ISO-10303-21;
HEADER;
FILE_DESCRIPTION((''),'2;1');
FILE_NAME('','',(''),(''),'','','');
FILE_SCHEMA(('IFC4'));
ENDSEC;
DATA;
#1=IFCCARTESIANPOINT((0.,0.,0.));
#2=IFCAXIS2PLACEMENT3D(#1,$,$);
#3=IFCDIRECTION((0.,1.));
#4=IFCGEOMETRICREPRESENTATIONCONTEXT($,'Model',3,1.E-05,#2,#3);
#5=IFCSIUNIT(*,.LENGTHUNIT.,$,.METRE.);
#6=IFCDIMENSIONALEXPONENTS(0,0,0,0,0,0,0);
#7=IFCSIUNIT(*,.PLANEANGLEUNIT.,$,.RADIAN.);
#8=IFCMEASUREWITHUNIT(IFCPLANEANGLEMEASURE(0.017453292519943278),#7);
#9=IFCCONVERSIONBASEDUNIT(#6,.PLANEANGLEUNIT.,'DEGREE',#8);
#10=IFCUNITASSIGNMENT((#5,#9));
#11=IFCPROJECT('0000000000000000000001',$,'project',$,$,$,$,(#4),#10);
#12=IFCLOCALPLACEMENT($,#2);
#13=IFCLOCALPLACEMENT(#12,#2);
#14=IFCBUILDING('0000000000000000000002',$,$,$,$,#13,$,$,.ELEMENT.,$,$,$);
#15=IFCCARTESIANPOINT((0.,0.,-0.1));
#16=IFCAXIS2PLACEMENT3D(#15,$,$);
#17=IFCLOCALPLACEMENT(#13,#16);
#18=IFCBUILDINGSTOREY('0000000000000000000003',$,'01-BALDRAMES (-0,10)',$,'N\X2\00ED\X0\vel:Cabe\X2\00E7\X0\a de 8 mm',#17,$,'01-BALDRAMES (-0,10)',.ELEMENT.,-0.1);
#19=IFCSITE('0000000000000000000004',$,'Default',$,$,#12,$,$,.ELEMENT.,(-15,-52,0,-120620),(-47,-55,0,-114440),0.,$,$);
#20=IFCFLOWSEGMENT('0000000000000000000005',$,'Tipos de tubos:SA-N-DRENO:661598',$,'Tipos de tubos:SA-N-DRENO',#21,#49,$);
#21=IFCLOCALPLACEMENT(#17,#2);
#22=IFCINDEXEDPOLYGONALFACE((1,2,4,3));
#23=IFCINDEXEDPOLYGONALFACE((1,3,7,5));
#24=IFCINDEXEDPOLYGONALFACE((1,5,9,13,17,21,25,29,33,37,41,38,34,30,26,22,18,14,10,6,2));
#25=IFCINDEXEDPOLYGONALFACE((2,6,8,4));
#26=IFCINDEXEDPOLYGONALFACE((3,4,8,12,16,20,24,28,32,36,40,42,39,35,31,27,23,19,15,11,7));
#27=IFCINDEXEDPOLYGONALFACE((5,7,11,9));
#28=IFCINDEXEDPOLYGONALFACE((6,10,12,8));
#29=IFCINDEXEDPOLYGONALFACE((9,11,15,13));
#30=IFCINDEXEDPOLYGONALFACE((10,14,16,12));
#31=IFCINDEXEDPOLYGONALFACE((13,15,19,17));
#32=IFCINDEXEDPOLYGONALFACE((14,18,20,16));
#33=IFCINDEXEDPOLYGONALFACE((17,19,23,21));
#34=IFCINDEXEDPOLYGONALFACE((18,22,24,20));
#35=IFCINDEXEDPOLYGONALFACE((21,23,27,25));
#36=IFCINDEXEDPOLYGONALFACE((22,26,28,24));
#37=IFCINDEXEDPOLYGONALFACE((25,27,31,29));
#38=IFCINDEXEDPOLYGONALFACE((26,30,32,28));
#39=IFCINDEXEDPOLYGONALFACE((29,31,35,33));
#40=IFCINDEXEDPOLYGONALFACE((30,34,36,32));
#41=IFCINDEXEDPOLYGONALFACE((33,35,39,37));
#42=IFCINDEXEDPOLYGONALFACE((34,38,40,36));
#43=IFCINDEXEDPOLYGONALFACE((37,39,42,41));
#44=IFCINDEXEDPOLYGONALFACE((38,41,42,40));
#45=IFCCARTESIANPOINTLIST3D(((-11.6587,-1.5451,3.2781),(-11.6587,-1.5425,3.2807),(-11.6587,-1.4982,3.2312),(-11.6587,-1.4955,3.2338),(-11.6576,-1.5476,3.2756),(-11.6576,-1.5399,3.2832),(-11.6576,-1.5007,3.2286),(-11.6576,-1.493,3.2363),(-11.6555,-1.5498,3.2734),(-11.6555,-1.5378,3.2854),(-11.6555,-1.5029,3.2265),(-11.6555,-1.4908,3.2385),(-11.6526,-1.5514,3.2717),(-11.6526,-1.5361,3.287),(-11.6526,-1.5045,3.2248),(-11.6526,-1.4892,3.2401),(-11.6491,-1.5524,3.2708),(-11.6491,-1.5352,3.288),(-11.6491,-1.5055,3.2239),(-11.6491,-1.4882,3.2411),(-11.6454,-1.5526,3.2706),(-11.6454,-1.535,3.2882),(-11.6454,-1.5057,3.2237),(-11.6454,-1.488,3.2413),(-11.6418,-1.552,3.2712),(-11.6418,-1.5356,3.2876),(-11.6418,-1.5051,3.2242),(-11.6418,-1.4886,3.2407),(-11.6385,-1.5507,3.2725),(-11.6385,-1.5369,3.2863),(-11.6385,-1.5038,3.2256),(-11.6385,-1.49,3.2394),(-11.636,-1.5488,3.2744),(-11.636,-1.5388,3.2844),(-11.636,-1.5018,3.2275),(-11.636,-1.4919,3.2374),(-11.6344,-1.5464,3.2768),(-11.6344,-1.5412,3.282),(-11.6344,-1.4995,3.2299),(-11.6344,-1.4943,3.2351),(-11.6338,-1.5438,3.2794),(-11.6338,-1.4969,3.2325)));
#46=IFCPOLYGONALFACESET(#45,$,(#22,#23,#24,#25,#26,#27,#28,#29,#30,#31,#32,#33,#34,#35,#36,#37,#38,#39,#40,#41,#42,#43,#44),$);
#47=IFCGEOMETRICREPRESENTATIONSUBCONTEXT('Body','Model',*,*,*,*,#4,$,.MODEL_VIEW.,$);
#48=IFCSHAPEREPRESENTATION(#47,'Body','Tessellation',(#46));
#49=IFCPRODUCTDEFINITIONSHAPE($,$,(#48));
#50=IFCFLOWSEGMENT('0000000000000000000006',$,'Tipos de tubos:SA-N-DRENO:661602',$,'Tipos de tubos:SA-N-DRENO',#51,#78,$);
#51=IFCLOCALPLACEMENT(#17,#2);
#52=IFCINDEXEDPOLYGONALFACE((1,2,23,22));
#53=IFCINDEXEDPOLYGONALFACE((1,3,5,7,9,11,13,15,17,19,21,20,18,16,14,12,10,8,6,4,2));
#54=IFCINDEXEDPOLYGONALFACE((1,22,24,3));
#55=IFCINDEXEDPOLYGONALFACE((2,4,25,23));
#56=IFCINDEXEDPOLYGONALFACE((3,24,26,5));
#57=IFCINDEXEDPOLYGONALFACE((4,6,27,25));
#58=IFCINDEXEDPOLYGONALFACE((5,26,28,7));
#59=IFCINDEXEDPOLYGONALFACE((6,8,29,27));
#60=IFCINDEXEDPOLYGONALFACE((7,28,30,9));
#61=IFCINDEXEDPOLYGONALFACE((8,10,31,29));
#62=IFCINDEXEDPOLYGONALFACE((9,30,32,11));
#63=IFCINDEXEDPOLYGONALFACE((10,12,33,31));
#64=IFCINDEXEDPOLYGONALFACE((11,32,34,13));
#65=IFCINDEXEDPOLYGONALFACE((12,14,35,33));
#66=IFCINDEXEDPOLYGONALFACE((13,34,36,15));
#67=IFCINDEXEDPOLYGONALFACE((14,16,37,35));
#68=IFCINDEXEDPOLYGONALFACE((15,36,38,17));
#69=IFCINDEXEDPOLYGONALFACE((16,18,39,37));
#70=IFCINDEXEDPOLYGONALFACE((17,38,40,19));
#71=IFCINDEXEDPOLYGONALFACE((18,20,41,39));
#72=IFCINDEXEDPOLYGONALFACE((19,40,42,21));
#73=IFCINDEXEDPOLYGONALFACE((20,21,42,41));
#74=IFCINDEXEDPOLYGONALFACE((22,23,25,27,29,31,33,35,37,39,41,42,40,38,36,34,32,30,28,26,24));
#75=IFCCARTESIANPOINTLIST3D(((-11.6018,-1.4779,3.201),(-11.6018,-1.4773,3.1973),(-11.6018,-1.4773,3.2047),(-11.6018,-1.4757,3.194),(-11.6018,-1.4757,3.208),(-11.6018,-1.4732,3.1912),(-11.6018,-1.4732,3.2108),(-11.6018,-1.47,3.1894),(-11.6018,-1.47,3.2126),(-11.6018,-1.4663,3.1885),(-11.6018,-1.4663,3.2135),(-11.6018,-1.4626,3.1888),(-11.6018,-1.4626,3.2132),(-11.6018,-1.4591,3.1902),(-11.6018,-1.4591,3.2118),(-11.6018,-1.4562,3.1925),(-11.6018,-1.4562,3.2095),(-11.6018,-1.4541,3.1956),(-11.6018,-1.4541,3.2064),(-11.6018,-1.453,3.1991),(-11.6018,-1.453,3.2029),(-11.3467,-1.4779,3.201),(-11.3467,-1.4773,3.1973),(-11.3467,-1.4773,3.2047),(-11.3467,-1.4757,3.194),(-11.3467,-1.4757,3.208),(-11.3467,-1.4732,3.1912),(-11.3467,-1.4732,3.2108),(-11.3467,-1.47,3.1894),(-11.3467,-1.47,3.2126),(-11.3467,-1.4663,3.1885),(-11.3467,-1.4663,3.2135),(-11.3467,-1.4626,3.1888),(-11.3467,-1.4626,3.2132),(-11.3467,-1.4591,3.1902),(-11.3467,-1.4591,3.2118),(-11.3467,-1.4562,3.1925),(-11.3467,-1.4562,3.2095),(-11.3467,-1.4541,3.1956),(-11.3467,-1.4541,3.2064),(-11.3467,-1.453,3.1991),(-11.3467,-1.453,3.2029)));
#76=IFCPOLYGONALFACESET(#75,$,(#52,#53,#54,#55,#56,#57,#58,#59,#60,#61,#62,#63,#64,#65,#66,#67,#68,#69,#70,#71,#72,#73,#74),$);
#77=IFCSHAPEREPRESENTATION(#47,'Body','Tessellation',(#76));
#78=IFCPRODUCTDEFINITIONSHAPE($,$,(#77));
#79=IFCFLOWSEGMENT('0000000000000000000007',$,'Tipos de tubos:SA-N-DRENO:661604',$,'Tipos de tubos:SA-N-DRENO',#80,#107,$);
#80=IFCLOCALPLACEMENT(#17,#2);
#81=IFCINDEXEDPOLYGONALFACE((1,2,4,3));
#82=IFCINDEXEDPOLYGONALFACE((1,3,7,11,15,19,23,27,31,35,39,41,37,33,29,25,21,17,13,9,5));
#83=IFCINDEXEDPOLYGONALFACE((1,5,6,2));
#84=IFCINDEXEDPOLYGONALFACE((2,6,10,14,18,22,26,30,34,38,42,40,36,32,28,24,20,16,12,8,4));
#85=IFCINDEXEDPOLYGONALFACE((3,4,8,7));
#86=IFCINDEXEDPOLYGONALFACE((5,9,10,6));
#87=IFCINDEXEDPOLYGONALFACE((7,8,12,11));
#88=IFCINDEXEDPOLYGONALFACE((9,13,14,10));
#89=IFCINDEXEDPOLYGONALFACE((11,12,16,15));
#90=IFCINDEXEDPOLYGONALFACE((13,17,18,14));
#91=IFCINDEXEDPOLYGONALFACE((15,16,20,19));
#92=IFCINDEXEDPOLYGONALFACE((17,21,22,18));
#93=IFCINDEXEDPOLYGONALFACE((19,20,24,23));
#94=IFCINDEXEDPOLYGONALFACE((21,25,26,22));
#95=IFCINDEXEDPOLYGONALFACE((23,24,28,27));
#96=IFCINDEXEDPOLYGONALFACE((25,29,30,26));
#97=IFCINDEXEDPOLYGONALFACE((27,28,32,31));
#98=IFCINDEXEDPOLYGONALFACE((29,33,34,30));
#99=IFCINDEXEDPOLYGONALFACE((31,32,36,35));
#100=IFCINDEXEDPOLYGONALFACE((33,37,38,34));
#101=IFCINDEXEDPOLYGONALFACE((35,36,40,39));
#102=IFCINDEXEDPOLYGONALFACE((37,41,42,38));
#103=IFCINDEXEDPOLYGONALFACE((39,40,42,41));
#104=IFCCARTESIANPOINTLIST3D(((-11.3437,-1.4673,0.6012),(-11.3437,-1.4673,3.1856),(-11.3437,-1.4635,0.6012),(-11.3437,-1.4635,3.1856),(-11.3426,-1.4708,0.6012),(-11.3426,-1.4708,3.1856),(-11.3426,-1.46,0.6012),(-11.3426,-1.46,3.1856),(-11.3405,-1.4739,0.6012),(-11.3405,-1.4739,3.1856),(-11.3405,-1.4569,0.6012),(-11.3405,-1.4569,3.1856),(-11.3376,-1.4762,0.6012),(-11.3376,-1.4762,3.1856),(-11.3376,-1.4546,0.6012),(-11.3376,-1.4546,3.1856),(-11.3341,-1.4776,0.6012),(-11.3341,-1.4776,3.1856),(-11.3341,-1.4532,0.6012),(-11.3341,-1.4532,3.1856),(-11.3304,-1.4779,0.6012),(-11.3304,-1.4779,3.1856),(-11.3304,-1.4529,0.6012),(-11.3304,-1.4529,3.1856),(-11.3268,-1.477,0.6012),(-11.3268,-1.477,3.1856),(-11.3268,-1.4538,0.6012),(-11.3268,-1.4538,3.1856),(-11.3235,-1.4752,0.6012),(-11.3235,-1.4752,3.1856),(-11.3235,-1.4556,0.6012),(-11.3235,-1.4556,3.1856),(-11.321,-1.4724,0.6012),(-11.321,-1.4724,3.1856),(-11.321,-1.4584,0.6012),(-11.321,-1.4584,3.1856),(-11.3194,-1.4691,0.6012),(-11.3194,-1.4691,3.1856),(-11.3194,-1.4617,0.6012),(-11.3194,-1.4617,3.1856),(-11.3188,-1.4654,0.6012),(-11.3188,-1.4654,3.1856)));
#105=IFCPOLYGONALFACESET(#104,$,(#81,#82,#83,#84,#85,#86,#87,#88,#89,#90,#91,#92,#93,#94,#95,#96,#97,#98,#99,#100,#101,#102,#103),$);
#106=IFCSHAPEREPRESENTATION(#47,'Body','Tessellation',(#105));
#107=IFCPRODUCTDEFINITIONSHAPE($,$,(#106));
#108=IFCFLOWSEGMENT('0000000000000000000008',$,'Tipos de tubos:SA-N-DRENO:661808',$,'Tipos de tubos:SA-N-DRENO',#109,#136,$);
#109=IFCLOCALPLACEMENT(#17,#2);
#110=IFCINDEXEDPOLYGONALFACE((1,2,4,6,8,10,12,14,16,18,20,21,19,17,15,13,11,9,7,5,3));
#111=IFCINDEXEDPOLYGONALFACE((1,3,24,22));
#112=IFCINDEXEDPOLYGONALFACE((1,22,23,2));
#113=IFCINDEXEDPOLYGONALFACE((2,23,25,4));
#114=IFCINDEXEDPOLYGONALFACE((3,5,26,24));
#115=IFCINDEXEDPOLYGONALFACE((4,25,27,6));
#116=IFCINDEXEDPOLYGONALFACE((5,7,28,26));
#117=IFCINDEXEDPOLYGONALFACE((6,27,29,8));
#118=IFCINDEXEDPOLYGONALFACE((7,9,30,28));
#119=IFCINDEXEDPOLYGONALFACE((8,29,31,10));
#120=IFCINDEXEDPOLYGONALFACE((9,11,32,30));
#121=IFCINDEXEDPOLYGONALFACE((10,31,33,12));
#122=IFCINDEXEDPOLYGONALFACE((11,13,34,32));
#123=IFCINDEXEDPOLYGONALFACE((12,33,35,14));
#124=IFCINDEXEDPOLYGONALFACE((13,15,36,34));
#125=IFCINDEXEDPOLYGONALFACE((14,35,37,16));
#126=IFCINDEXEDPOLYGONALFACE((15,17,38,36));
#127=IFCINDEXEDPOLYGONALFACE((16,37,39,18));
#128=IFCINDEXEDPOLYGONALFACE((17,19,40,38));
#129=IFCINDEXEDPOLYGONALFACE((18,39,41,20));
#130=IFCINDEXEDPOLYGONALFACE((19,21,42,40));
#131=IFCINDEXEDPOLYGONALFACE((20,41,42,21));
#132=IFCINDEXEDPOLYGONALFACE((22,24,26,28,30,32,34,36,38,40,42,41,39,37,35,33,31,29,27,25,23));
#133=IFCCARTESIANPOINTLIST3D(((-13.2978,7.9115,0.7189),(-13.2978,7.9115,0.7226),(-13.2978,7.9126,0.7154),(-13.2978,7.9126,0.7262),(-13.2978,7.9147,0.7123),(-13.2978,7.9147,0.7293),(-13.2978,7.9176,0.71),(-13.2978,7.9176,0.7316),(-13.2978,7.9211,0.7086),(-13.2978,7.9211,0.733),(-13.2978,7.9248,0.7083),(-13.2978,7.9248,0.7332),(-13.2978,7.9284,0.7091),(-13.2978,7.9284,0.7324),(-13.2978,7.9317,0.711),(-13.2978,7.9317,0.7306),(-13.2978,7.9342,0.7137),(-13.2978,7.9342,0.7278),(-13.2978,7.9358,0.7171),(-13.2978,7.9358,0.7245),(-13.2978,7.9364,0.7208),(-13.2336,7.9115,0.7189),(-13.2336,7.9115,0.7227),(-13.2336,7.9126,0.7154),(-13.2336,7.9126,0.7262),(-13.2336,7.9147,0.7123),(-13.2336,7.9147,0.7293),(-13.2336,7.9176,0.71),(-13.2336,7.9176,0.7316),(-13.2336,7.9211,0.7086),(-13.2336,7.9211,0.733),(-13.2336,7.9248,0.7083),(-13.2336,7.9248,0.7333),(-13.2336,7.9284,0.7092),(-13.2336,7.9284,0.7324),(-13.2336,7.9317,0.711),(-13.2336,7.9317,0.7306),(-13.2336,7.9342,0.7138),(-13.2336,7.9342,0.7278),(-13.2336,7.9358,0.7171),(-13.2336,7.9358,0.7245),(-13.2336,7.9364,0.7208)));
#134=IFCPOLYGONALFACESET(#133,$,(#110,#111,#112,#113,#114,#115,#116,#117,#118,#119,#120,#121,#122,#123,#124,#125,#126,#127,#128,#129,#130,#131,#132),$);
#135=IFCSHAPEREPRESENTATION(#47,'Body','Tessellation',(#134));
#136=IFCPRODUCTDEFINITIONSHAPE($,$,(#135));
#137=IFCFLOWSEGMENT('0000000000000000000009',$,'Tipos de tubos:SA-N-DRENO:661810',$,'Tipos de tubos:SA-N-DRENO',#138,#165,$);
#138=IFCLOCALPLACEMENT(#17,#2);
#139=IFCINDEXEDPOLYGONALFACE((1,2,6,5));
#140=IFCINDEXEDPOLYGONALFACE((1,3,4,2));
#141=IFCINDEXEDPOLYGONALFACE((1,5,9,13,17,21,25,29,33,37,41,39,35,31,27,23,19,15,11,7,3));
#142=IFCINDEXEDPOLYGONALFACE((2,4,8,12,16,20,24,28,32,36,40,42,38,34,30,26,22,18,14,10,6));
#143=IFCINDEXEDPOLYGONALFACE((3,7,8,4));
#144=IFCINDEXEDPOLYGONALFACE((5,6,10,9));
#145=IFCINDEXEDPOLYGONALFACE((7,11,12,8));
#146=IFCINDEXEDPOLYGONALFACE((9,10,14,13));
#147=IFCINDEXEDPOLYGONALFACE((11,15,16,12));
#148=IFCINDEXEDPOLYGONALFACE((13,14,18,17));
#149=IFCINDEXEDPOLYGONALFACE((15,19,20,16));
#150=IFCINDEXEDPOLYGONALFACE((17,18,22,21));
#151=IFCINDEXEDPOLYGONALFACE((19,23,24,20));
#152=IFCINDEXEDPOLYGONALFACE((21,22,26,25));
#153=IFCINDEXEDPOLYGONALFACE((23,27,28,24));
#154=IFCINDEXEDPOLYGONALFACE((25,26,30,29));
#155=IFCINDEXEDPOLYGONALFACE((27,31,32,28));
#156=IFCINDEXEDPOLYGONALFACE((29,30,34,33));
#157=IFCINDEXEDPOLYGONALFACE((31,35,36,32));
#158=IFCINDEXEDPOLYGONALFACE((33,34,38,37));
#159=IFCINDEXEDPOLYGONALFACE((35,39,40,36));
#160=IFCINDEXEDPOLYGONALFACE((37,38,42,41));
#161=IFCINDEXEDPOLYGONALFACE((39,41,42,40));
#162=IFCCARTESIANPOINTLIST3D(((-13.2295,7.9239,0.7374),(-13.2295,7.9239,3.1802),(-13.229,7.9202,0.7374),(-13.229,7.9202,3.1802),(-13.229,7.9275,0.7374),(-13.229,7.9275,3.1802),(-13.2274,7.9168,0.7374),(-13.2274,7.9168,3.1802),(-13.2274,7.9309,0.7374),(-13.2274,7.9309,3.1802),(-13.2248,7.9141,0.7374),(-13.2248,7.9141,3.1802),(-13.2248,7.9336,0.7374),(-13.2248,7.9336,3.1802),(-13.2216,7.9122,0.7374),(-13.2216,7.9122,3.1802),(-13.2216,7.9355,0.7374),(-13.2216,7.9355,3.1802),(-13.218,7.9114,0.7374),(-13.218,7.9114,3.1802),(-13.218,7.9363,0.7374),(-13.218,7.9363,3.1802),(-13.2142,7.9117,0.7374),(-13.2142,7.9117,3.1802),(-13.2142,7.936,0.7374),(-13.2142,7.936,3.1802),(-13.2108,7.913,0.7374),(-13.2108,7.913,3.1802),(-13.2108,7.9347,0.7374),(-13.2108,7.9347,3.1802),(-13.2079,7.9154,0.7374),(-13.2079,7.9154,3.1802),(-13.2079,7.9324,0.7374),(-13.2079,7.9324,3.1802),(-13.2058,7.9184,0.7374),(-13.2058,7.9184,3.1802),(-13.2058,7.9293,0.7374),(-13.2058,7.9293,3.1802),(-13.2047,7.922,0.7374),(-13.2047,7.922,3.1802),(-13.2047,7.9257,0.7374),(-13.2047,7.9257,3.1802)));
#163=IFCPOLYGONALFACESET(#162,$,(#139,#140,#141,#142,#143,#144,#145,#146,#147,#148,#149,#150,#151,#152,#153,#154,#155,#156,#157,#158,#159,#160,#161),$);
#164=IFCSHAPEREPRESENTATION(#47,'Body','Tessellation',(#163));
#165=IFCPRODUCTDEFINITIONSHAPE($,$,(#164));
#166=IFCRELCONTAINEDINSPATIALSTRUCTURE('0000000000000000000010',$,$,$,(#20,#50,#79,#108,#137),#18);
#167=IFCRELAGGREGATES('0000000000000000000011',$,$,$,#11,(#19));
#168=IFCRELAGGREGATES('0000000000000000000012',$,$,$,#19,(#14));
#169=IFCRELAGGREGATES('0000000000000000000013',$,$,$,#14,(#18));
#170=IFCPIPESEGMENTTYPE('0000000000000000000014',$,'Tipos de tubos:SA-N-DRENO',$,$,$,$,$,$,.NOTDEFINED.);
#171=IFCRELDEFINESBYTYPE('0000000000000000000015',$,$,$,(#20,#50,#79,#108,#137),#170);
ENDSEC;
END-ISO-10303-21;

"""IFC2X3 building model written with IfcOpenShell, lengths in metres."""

from ifc_helpers import new_model, entity, si_unit, converted_unit, direction, frame, frame_2d, origin, origin_2d_with_axis, place, context, subcontext, project, spatial, circle, extrude, type_object, element, save


model = new_model("IFC2X3")

# Units and contexts
model_context = context("Model", 3, precision=1e-05, world=origin(), true_north=direction((0.0, 1.0)))
body_context = subcontext(model_context, "Body", "Model", "MODEL_VIEW")
ifc_project = project(units=[si_unit("LENGTHUNIT", "METRE"), converted_unit("PLANEANGLEUNIT", "DEGREE", entity("IfcPlaneAngleMeasure", 0.017453292519943278), si_unit("PLANEANGLEUNIT", "RADIAN"), dimensions=[0, 0, 0, 0, 0, 0, 0])], contexts=[model_context])

# Site, building, storey
site_placement = place(None, origin())
site = spatial("IfcSite", under=ifc_project, at=site_placement, Name="Default", CompositionType="ELEMENT", RefLatitude=(-15, -52, 0, -120620), RefLongitude=(-47, -55, 0, -114440), RefElevation=0.0)
building_placement = place(site_placement, origin())
building = spatial("IfcBuilding", under=site, at=building_placement, CompositionType="ELEMENT")
storey_placement = place(building_placement, frame((0.0, 0.0, -0.1)))
storey = spatial("IfcBuildingStorey", under=building, at=storey_placement, Name="01-BALDRAMES (-0,10)", ObjectType="Nível:Cabeça de 8 mm", LongName="01-BALDRAMES (-0,10)", CompositionType="ELEMENT", Elevation=-0.1)

# Flow segments
pipe_segment_type_1 = type_object("IfcPipeSegmentType", Name="Tipos de tubos:SA-N-DRENO", PredefinedType="NOTDEFINED")
flow_segment_1_placement = place(storey_placement, origin())
element("IfcFlowSegment", 1, at=flow_segment_1_placement, inside=storey, type_object=pipe_segment_type_1, Name="Tipos de tubos:SA-N-DRENO:661598", ObjectType="Tipos de tubos:SA-N-DRENO", context=body_context, shape_type="SweptSolid", body=[
    extrude(circle(Radius=0.0125, at=origin_2d_with_axis()), frame((-11.6463, -1.5438, 3.2794), z_axis=(0.000029, 0.707107, -0.707107), x_axis=(1.0, -0.000041, 0.0)), (0.0, 0.0, 1.0), 0.0664),
])
flow_segment_2_placement = place(storey_placement, origin())
element("IfcFlowSegment", 2, at=flow_segment_2_placement, inside=storey, type_object=pipe_segment_type_1, Name="Tipos de tubos:SA-N-DRENO:661602", ObjectType="Tipos de tubos:SA-N-DRENO", context=body_context, shape_type="SweptSolid", body=[
    extrude(circle(Radius=0.0125, at=origin_2d_with_axis()), frame((-11.6018, -1.4654, 3.201), z_axis=(1.0, -0.000007, 0.0), x_axis=(-0.000007, -1.0, 0.0)), (0.0, 0.0, 1.0), 0.2551),
])
flow_segment_3_placement = place(storey_placement, origin())
element("IfcFlowSegment", 3, at=flow_segment_3_placement, inside=storey, type_object=pipe_segment_type_1, Name="Tipos de tubos:SA-N-DRENO:661604", ObjectType="Tipos de tubos:SA-N-DRENO", context=body_context, shape_type="SweptSolid", body=[
    extrude(circle(Radius=0.0125, at=frame_2d((0.0, 0.0), x_axis=(1.0, 0.0))), frame((-11.3313, -1.4654, 0.6012)), (0.0, 0.0, 1.0), 2.5844),
])
flow_segment_4_placement = place(storey_placement, origin())
element("IfcFlowSegment", 4, at=flow_segment_4_placement, inside=storey, type_object=pipe_segment_type_1, Name="Tipos de tubos:SA-N-DRENO:661808", ObjectType="Tipos de tubos:SA-N-DRENO", context=body_context, shape_type="SweptSolid", body=[
    extrude(circle(Radius=0.0125, at=origin_2d_with_axis()), frame((-13.2978, 7.9239, 0.7208), z_axis=(1.0, 0.000003, 0.000178), x_axis=(-0.000003, 1.0, 0.0)), (0.0, 0.0, 1.0), 0.0641),
])
flow_segment_5_placement = place(storey_placement, origin())
element("IfcFlowSegment", 5, at=flow_segment_5_placement, inside=storey, type_object=pipe_segment_type_1, Name="Tipos de tubos:SA-N-DRENO:661810", ObjectType="Tipos de tubos:SA-N-DRENO", context=body_context, shape_type="SweptSolid", body=[
    extrude(circle(Radius=0.0125, at=origin_2d_with_axis()), frame((-13.217, 7.9239, 0.7374), z_axis=(0.000002, -0.000001, 1.0), x_axis=(-1.0, 0.0, 0.000002)), (0.0, 0.0, 1.0), 2.4428),
])

save(model, "model.ifc")
